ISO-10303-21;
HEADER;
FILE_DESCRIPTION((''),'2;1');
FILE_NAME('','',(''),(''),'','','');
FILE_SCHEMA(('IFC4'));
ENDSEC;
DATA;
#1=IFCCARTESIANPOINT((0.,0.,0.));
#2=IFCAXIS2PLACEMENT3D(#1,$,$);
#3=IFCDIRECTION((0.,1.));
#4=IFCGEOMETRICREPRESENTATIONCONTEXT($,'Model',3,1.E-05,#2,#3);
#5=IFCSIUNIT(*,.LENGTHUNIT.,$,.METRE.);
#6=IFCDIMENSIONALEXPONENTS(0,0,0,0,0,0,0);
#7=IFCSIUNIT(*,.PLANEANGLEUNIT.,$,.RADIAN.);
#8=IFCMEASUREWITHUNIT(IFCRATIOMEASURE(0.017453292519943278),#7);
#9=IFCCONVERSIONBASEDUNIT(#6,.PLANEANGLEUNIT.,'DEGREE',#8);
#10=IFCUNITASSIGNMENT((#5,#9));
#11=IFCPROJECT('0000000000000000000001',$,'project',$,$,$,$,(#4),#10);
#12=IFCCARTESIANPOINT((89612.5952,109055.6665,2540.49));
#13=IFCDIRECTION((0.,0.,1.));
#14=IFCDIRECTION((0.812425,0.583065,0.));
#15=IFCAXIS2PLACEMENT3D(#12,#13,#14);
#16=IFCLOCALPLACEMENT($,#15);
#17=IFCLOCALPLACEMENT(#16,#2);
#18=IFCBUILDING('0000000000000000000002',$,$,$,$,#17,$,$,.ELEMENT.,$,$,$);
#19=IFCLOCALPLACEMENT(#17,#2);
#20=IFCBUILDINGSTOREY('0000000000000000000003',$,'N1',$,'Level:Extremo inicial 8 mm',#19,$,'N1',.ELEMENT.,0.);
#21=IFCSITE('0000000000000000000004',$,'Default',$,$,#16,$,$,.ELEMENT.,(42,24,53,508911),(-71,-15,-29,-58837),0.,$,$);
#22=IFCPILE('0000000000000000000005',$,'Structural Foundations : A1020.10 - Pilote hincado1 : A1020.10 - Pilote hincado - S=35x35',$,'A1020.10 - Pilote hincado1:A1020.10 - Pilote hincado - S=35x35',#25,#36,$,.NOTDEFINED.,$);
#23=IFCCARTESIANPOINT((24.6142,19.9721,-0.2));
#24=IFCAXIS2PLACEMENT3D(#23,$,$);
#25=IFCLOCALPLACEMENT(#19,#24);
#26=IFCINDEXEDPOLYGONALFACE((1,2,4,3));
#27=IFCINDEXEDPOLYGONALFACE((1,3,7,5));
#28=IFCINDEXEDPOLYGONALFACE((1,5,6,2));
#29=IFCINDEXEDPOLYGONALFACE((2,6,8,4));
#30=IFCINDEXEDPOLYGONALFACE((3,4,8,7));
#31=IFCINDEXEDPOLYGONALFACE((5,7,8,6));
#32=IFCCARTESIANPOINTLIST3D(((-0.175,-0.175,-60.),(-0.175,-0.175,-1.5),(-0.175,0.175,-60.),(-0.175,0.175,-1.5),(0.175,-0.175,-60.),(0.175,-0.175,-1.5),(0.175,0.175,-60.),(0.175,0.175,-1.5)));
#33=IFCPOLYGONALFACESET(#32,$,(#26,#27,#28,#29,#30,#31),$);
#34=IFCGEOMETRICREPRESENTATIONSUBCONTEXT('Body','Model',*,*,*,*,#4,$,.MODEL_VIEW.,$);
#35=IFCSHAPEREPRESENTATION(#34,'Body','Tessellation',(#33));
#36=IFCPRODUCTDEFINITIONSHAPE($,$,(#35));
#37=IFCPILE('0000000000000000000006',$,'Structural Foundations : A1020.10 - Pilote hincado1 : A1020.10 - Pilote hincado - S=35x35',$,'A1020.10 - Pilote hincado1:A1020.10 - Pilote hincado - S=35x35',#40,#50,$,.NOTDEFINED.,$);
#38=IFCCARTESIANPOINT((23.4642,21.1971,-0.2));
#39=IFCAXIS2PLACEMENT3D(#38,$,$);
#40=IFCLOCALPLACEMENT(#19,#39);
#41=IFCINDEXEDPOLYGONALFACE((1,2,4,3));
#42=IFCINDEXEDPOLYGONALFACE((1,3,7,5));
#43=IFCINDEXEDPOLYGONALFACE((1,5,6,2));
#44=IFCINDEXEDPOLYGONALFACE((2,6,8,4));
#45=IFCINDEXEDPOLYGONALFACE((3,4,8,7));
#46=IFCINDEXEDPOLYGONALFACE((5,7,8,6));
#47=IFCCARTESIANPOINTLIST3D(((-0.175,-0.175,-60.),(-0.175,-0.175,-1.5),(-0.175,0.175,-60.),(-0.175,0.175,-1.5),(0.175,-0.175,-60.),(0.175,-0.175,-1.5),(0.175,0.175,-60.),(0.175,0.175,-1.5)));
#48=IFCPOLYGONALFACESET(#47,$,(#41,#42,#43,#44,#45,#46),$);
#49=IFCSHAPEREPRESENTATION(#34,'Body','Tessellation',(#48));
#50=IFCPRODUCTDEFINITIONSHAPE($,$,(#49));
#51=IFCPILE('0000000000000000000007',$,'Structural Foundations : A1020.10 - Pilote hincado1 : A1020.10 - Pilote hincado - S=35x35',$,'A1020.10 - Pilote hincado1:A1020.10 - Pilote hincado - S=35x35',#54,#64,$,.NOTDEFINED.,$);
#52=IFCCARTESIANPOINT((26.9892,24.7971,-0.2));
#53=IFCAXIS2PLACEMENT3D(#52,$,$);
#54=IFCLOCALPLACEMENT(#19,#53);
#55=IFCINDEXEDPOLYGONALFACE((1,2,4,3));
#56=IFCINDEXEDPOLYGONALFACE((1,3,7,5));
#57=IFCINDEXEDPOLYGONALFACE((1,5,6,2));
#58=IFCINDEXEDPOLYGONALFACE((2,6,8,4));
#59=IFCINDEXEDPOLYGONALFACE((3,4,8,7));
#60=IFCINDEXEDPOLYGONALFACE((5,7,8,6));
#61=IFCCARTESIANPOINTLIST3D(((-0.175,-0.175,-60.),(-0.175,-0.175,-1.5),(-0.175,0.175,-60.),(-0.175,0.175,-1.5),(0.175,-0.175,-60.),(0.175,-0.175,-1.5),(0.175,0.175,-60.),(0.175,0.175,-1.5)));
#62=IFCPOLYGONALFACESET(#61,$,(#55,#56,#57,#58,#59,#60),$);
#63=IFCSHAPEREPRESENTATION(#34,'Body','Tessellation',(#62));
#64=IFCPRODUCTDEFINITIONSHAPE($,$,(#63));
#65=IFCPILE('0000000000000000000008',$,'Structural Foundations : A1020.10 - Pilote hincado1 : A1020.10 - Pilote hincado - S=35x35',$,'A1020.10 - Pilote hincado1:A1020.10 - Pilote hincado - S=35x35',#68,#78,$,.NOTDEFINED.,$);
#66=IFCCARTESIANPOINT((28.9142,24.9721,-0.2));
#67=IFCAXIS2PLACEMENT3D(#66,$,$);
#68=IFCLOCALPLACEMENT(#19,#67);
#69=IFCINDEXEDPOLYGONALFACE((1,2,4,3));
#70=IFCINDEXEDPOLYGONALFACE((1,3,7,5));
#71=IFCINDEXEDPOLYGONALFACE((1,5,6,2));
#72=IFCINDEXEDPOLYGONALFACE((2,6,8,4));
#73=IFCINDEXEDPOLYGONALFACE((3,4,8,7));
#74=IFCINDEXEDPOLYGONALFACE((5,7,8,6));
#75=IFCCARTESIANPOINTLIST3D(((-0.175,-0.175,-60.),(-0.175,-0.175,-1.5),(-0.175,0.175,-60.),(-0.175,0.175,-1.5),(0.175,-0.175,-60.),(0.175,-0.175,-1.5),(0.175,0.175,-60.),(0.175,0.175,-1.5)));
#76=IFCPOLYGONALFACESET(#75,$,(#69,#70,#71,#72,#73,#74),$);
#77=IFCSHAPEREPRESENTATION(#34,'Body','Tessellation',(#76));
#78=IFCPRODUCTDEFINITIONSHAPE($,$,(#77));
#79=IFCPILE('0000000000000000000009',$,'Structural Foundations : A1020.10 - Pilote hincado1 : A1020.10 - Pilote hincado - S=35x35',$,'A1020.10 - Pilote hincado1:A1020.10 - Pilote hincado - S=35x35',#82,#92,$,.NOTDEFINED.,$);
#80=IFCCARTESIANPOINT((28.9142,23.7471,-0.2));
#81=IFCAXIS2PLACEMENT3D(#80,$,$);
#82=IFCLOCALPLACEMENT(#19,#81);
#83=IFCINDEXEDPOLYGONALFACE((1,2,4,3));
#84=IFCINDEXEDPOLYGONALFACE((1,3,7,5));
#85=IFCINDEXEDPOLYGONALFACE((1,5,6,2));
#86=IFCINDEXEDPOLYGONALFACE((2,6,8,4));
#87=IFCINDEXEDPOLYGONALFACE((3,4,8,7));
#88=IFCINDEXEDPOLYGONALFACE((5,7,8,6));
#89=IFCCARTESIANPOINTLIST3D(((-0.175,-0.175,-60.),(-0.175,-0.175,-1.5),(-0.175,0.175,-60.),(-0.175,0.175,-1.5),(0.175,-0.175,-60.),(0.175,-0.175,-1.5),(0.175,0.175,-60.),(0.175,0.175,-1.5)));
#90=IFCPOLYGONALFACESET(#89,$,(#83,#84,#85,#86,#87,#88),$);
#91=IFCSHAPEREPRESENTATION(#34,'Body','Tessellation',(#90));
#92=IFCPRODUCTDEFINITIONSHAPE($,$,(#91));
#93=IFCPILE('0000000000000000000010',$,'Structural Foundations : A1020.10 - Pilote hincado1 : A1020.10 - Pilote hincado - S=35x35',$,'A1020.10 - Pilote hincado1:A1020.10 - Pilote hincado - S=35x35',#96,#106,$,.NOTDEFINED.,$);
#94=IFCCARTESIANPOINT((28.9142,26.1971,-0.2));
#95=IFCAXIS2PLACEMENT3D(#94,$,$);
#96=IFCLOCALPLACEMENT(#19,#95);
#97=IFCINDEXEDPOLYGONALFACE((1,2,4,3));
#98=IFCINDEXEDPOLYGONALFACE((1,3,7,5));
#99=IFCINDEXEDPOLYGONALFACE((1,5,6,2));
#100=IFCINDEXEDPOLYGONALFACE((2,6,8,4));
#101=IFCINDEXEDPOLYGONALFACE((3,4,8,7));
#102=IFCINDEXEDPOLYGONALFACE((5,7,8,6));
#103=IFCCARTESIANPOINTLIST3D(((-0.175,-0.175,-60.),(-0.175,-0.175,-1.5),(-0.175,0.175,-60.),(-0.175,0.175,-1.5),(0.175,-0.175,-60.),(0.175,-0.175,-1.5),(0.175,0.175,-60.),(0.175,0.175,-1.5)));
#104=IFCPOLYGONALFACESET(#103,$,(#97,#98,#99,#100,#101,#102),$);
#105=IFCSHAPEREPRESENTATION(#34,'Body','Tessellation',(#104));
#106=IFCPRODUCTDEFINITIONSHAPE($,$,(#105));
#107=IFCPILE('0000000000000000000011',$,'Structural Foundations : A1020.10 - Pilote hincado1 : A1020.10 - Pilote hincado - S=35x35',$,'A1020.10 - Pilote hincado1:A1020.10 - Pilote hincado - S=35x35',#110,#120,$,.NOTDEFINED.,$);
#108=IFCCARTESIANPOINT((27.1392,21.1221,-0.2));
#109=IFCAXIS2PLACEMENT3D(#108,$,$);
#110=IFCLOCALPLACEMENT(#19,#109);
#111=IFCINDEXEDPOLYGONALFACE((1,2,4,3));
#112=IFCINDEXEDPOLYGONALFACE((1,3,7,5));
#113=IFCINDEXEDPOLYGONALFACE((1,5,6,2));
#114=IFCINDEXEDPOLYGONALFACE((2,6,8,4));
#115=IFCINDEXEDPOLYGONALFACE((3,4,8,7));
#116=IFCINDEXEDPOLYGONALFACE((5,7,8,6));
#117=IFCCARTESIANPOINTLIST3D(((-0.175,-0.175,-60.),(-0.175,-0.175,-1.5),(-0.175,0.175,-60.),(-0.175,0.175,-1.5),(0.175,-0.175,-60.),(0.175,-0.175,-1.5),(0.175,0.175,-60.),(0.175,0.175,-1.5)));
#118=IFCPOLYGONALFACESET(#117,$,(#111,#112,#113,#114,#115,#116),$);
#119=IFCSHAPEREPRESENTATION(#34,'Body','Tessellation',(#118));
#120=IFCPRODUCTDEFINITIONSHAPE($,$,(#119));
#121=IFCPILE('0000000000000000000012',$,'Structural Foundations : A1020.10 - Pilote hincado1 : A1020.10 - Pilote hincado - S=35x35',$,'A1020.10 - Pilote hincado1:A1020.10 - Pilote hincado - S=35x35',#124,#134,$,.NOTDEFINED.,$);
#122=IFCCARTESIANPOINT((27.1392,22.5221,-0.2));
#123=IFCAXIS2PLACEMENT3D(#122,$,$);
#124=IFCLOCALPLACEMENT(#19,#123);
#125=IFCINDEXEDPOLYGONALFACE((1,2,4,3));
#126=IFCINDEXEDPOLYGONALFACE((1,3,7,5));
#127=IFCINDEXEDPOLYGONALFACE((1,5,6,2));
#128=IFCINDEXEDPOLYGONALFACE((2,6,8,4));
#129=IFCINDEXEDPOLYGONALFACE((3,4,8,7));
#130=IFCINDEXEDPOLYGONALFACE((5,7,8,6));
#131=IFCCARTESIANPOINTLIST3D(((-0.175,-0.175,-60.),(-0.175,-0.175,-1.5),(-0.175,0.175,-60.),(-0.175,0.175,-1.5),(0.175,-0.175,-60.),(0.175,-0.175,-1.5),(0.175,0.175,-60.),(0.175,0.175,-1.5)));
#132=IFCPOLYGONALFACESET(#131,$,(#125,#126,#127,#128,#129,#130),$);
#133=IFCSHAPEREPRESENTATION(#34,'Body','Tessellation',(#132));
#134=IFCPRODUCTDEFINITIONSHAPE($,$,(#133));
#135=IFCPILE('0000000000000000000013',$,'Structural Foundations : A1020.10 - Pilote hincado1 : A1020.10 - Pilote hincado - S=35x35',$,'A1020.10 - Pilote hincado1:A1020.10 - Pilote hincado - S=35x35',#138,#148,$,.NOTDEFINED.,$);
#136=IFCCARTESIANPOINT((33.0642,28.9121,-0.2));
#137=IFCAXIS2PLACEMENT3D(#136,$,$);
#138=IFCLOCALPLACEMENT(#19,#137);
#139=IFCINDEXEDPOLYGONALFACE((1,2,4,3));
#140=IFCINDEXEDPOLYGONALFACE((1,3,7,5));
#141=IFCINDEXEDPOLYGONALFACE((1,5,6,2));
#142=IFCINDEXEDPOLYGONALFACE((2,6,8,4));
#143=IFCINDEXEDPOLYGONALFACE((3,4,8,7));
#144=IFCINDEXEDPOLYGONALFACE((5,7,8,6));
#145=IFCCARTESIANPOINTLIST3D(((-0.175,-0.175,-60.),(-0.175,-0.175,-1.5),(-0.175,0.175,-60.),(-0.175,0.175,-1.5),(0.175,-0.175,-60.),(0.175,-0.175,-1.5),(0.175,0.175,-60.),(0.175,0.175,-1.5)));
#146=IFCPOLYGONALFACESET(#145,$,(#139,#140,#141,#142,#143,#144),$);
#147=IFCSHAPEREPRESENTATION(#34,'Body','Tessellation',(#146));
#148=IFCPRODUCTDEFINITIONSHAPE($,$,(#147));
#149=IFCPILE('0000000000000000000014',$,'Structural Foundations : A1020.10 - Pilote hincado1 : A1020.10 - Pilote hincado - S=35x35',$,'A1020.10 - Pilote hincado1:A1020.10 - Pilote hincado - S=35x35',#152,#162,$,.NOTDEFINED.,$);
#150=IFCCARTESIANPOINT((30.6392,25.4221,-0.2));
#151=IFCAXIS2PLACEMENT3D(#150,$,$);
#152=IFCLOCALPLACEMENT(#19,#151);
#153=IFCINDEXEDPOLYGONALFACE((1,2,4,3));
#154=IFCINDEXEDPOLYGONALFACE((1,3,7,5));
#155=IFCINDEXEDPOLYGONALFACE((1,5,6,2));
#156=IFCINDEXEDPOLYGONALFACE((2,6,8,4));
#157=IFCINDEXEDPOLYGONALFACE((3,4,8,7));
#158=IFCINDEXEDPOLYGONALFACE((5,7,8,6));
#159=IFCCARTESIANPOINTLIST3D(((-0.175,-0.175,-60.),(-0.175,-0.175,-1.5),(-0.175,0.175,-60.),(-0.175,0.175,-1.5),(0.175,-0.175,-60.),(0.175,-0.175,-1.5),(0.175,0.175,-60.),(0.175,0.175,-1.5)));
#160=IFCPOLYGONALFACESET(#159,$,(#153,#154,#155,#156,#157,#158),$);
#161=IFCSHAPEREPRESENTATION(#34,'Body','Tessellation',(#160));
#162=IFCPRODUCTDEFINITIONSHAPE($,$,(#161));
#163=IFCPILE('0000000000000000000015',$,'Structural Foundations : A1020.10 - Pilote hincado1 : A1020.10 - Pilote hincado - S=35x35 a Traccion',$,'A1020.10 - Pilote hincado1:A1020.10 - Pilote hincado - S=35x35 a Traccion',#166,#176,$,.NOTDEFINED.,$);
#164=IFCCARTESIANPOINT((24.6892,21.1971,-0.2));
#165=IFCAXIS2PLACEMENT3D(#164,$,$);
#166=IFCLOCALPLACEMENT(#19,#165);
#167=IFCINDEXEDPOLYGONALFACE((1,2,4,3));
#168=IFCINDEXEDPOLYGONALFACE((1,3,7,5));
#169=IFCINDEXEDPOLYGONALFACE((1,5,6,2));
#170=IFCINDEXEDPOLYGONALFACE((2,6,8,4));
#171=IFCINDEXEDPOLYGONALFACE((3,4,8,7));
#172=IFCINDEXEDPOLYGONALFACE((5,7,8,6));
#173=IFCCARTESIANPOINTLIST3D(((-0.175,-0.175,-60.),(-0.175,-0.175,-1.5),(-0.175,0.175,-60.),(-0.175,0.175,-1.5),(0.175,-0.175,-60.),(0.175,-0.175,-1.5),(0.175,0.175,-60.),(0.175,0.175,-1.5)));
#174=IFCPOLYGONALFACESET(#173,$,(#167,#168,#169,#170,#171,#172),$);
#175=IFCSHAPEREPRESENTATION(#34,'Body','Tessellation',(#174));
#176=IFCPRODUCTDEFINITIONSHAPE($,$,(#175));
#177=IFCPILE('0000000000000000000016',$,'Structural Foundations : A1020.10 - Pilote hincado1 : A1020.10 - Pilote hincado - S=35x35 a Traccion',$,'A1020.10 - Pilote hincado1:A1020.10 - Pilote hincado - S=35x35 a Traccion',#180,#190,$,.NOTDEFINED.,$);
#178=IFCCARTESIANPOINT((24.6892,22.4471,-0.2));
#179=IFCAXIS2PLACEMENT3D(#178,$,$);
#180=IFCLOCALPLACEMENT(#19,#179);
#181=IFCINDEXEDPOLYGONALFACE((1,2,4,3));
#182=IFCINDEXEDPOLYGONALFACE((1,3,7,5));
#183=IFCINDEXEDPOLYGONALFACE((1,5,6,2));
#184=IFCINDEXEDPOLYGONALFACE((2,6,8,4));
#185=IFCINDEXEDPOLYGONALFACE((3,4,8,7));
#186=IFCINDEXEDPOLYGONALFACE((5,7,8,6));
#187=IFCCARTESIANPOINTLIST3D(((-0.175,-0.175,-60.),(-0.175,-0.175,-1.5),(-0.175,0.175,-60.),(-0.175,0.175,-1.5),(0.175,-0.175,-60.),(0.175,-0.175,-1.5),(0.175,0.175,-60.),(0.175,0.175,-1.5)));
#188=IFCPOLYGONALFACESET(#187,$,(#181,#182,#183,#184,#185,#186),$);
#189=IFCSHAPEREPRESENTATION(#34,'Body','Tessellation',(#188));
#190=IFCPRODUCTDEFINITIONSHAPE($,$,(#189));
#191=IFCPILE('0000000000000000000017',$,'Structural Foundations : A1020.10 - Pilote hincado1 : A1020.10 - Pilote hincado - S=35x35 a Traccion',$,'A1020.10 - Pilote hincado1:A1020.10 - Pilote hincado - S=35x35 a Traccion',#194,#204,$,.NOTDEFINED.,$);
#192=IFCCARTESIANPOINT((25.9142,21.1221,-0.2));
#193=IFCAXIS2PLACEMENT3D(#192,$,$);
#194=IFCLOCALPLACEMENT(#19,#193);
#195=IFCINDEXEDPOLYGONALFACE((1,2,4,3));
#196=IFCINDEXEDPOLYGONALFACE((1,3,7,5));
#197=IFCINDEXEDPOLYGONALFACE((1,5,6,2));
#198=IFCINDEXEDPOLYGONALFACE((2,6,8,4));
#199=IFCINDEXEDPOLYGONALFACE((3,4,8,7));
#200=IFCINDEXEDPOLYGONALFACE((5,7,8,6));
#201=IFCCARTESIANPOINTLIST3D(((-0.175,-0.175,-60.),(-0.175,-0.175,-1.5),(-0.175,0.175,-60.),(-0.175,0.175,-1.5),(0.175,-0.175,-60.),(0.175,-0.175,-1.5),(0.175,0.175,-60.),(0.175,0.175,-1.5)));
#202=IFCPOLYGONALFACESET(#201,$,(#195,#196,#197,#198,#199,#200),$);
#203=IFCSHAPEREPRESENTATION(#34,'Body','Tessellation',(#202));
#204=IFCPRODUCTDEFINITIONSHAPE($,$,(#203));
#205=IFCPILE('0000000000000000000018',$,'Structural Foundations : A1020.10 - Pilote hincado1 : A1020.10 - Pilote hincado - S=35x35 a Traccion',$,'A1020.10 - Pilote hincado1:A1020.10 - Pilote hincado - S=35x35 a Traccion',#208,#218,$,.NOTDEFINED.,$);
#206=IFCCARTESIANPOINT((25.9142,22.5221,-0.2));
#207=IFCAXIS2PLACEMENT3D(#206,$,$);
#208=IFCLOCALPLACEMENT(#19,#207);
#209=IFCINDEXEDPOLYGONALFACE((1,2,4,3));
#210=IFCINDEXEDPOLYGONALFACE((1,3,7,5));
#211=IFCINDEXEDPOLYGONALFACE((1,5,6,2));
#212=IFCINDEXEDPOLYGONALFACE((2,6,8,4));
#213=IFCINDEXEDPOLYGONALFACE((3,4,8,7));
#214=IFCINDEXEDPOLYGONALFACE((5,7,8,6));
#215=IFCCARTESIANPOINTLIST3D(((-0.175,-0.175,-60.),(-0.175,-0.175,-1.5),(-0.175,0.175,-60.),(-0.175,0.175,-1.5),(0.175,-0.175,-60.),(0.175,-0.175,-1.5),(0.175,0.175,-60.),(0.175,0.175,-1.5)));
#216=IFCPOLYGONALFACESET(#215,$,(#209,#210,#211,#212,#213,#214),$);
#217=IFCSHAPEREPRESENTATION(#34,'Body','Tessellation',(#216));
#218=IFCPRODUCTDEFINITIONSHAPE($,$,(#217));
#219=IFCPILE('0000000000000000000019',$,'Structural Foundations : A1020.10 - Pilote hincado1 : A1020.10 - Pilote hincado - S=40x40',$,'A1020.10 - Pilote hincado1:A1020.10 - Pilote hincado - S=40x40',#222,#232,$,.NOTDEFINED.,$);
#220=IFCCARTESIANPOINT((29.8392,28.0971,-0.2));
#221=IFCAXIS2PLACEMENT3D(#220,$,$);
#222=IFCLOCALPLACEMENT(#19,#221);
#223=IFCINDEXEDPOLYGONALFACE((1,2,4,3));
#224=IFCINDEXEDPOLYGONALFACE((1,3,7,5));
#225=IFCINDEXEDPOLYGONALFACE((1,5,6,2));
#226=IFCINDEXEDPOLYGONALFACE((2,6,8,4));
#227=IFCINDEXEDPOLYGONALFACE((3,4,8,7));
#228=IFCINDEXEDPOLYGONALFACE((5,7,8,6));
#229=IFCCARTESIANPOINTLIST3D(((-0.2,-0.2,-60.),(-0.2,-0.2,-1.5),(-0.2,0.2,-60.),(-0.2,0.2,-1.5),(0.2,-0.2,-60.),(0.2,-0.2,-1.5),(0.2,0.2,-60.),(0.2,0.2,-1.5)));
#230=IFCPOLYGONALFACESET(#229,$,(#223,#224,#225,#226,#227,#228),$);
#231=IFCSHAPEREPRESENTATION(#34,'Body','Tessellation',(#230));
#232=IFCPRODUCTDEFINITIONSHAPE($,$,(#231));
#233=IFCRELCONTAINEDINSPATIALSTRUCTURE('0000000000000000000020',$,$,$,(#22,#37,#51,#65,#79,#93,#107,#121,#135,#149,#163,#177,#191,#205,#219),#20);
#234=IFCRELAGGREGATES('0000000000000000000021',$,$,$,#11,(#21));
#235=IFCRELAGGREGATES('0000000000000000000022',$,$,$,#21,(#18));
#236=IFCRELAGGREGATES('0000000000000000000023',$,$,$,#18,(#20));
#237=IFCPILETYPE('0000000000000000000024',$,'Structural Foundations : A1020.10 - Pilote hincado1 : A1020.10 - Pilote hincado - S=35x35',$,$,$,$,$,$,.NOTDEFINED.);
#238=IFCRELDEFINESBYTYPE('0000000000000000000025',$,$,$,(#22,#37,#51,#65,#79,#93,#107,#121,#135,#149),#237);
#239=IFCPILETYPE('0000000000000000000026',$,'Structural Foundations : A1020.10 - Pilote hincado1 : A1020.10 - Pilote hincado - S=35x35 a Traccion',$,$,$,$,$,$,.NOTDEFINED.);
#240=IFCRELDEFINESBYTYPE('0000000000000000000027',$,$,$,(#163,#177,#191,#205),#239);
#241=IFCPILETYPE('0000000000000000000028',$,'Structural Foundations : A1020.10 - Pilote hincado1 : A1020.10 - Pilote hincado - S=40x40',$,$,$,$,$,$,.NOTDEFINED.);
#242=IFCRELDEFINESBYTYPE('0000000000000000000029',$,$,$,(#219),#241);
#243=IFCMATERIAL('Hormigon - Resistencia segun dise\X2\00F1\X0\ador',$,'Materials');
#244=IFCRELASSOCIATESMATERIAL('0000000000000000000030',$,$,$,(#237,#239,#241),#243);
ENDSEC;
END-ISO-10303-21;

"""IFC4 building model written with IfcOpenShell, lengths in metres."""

from ifc_helpers import new_model, entity, si_unit, converted_unit, direction, frame, origin, origin_2d_with_axis, place, context, subcontext, project, spatial, polyline, segment, composite_curve, rectangle, outline, extrude, source, transform, mapped, material, material_profile, profile_set, type_object, type_shapes, element, save


model = new_model("IFC4")

# Units and contexts
model_context = context("Model", 3, precision=1e-05, world=origin(), true_north=direction((0.0, 1.0)))
body_context = subcontext(model_context, "Body", "Model", "MODEL_VIEW")
ifc_project = project(units=[si_unit("LENGTHUNIT", "METRE"), converted_unit("PLANEANGLEUNIT", "DEGREE", entity("IfcRatioMeasure", 0.017453292519943278), si_unit("PLANEANGLEUNIT", "RADIAN"), dimensions=[0, 0, 0, 0, 0, 0, 0])], contexts=[model_context])

# Site, building, storey
site_placement = place(None, frame((89612.5952, 109055.6665, 2540.49), z_axis=(0.0, 0.0, 1.0), x_axis=(0.812425, 0.583065, 0.0)))
site = spatial("IfcSite", under=ifc_project, at=site_placement, Name="Default", CompositionType="ELEMENT", RefLatitude=(42, 24, 53, 508911), RefLongitude=(-71, -15, -29, -58837), RefElevation=0.0)
building_placement = place(site_placement, origin())
building = spatial("IfcBuilding", under=site, at=building_placement, CompositionType="ELEMENT")
storey_placement = place(building_placement, origin())
storey = spatial("IfcBuildingStorey", under=building, at=storey_placement, Name="N1", ObjectType="Level:Extremo inicial 8 mm", LongName="N1", CompositionType="ELEMENT", Elevation=0.0)

# Piles
ifc_material_1 = material(Name="Hormigon - Resistencia segun diseñador", Category="Materials")
ifc_material_profile_1 = material_profile(ifc_material_1, outline(composite_curve([segment(polyline([(0.175, 0.175, -60.0), (0.175, -0.175, -60.0)]), True, "CONTINUOUS"), segment(polyline([(0.175, -0.175, -60.0), (-0.175, -0.175, -60.0)]), True, "CONTINUOUS"), segment(polyline([(-0.175, -0.175, -60.0), (-0.175, 0.175, -60.0)]), True, "CONTINUOUS"), segment(polyline([(-0.175, 0.175, -60.0), (0.175, 0.175, -60.0)]), True, "CONTINUOUS")], self_intersect=False), kind="CURVE"), Name="A1020.10 - Pilote hincado - S=35x35")
ifc_profile_set_1 = profile_set([ifc_material_profile_1], Name="A1020.10 - Pilote hincado - S=35x35")
pile_type_1 = type_object("IfcPileType", Name="Structural Foundations : A1020.10 - Pilote hincado1 : A1020.10 - Pilote hincado - S=35x35", PredefinedType="NOTDEFINED", material=ifc_profile_set_1)
shared_shape_1 = source(origin(), body_context, "Body", "SweptSolid", [
    extrude(rectangle(XDim=0.35, YDim=0.35, at=origin_2d_with_axis()), frame((0.0, 0.0, -60.0), z_axis=(0.0, 0.0, 1.0), x_axis=(0.0, -1.0, 0.0)), (0.0, 0.0, 1.0), 58.5),
])
type_shapes(pile_type_1, [shared_shape_1])
for number, where, name in (
    (1, (24.6142, 19.9721, -0.2), "Structural Foundations : A1020.10 - Pilote hincado1 : A1020.10 - Pilote hincado - S=35x35"),
    (2, (23.4642, 21.1971, -0.2), "Structural Foundations : A1020.10 - Pilote hincado1 : A1020.10 - Pilote hincado - S=35x35"),
    (3, (26.9892, 24.7971, -0.2), "Structural Foundations : A1020.10 - Pilote hincado1 : A1020.10 - Pilote hincado - S=35x35"),
    (4, (28.9142, 24.9721, -0.2), "Structural Foundations : A1020.10 - Pilote hincado1 : A1020.10 - Pilote hincado - S=35x35"),
    (5, (28.9142, 23.7471, -0.2), "Structural Foundations : A1020.10 - Pilote hincado1 : A1020.10 - Pilote hincado - S=35x35"),
    (6, (28.9142, 26.1971, -0.2), "Structural Foundations : A1020.10 - Pilote hincado1 : A1020.10 - Pilote hincado - S=35x35"),
    (7, (27.1392, 21.1221, -0.2), "Structural Foundations : A1020.10 - Pilote hincado1 : A1020.10 - Pilote hincado - S=35x35"),
    (8, (27.1392, 22.5221, -0.2), "Structural Foundations : A1020.10 - Pilote hincado1 : A1020.10 - Pilote hincado - S=35x35"),
    (9, (33.0642, 28.9121, -0.2), "Structural Foundations : A1020.10 - Pilote hincado1 : A1020.10 - Pilote hincado - S=35x35"),
    (10, (30.6392, 25.4221, -0.2), "Structural Foundations : A1020.10 - Pilote hincado1 : A1020.10 - Pilote hincado - S=35x35"),
):
    element("IfcPile", number, at=place(storey_placement, frame(where)), inside=storey, type_object=pile_type_1, Name=name, ObjectType="A1020.10 - Pilote hincado1:A1020.10 - Pilote hincado - S=35x35", PredefinedType="NOTDEFINED", context=body_context, shape_type="MappedRepresentation", body=[
        mapped(shared_shape_1, transform((0.0, 0.0, 0.0), scale=1.0)),
    ])
ifc_material_profile_2 = material_profile(ifc_material_1, outline(composite_curve([segment(polyline([(0.175, 0.175, -60.0), (0.175, -0.175, -60.0)]), True, "CONTINUOUS"), segment(polyline([(0.175, -0.175, -60.0), (-0.175, -0.175, -60.0)]), True, "CONTINUOUS"), segment(polyline([(-0.175, -0.175, -60.0), (-0.175, 0.175, -60.0)]), True, "CONTINUOUS"), segment(polyline([(-0.175, 0.175, -60.0), (0.175, 0.175, -60.0)]), True, "CONTINUOUS")], self_intersect=False), kind="CURVE"), Name="A1020.10 - Pilote hincado - S=35x35 a Traccion")
ifc_profile_set_2 = profile_set([ifc_material_profile_2], Name="A1020.10 - Pilote hincado - S=35x35 a Traccion")
pile_type_2 = type_object("IfcPileType", Name="Structural Foundations : A1020.10 - Pilote hincado1 : A1020.10 - Pilote hincado - S=35x35 a Traccion", PredefinedType="NOTDEFINED", material=ifc_profile_set_2)
shared_shape_2 = source(origin(), body_context, "Body", "SweptSolid", [
    extrude(rectangle(XDim=0.35, YDim=0.35, at=origin_2d_with_axis()), frame((0.0, 0.0, -60.0), z_axis=(0.0, 0.0, 1.0), x_axis=(0.0, -1.0, 0.0)), (0.0, 0.0, 1.0), 58.5),
])
type_shapes(pile_type_2, [shared_shape_2])
for number, where, name in (
    (11, (24.6892, 21.1971, -0.2), "Structural Foundations : A1020.10 - Pilote hincado1 : A1020.10 - Pilote hincado - S=35x35 a Traccion"),
    (12, (24.6892, 22.4471, -0.2), "Structural Foundations : A1020.10 - Pilote hincado1 : A1020.10 - Pilote hincado - S=35x35 a Traccion"),
    (13, (25.9142, 21.1221, -0.2), "Structural Foundations : A1020.10 - Pilote hincado1 : A1020.10 - Pilote hincado - S=35x35 a Traccion"),
    (14, (25.9142, 22.5221, -0.2), "Structural Foundations : A1020.10 - Pilote hincado1 : A1020.10 - Pilote hincado - S=35x35 a Traccion"),
):
    element("IfcPile", number, at=place(storey_placement, frame(where)), inside=storey, type_object=pile_type_2, Name=name, ObjectType="A1020.10 - Pilote hincado1:A1020.10 - Pilote hincado - S=35x35 a Traccion", PredefinedType="NOTDEFINED", context=body_context, shape_type="MappedRepresentation", body=[
        mapped(shared_shape_2, transform((0.0, 0.0, 0.0), scale=1.0)),
    ])
ifc_material_profile_3 = material_profile(ifc_material_1, outline(composite_curve([segment(polyline([(0.2, 0.2, -60.0), (0.2, -0.2, -60.0)]), True, "CONTINUOUS"), segment(polyline([(0.2, -0.2, -60.0), (-0.2, -0.2, -60.0)]), True, "CONTINUOUS"), segment(polyline([(-0.2, -0.2, -60.0), (-0.2, 0.2, -60.0)]), True, "CONTINUOUS"), segment(polyline([(-0.2, 0.2, -60.0), (0.2, 0.2, -60.0)]), True, "CONTINUOUS")], self_intersect=False), kind="CURVE"), Name="A1020.10 - Pilote hincado - S=40x40")
ifc_profile_set_3 = profile_set([ifc_material_profile_3], Name="A1020.10 - Pilote hincado - S=40x40")
pile_type_3 = type_object("IfcPileType", Name="Structural Foundations : A1020.10 - Pilote hincado1 : A1020.10 - Pilote hincado - S=40x40", PredefinedType="NOTDEFINED", material=ifc_profile_set_3)
shared_shape_3 = source(origin(), body_context, "Body", "SweptSolid", [
    extrude(rectangle(XDim=0.4, YDim=0.4, at=origin_2d_with_axis()), frame((0.0, 0.0, -60.0), z_axis=(0.0, 0.0, 1.0), x_axis=(0.0, -1.0, 0.0)), (0.0, 0.0, 1.0), 58.5),
])
type_shapes(pile_type_3, [shared_shape_3])
for number, where, name in (
    (15, (29.8392, 28.0971, -0.2), "Structural Foundations : A1020.10 - Pilote hincado1 : A1020.10 - Pilote hincado - S=40x40"),
):
    element("IfcPile", number, at=place(storey_placement, frame(where)), inside=storey, type_object=pile_type_3, Name=name, ObjectType="A1020.10 - Pilote hincado1:A1020.10 - Pilote hincado - S=40x40", PredefinedType="NOTDEFINED", context=body_context, shape_type="MappedRepresentation", body=[
        mapped(shared_shape_3, transform((0.0, 0.0, 0.0), scale=1.0)),
    ])

save(model, "model.ifc")
